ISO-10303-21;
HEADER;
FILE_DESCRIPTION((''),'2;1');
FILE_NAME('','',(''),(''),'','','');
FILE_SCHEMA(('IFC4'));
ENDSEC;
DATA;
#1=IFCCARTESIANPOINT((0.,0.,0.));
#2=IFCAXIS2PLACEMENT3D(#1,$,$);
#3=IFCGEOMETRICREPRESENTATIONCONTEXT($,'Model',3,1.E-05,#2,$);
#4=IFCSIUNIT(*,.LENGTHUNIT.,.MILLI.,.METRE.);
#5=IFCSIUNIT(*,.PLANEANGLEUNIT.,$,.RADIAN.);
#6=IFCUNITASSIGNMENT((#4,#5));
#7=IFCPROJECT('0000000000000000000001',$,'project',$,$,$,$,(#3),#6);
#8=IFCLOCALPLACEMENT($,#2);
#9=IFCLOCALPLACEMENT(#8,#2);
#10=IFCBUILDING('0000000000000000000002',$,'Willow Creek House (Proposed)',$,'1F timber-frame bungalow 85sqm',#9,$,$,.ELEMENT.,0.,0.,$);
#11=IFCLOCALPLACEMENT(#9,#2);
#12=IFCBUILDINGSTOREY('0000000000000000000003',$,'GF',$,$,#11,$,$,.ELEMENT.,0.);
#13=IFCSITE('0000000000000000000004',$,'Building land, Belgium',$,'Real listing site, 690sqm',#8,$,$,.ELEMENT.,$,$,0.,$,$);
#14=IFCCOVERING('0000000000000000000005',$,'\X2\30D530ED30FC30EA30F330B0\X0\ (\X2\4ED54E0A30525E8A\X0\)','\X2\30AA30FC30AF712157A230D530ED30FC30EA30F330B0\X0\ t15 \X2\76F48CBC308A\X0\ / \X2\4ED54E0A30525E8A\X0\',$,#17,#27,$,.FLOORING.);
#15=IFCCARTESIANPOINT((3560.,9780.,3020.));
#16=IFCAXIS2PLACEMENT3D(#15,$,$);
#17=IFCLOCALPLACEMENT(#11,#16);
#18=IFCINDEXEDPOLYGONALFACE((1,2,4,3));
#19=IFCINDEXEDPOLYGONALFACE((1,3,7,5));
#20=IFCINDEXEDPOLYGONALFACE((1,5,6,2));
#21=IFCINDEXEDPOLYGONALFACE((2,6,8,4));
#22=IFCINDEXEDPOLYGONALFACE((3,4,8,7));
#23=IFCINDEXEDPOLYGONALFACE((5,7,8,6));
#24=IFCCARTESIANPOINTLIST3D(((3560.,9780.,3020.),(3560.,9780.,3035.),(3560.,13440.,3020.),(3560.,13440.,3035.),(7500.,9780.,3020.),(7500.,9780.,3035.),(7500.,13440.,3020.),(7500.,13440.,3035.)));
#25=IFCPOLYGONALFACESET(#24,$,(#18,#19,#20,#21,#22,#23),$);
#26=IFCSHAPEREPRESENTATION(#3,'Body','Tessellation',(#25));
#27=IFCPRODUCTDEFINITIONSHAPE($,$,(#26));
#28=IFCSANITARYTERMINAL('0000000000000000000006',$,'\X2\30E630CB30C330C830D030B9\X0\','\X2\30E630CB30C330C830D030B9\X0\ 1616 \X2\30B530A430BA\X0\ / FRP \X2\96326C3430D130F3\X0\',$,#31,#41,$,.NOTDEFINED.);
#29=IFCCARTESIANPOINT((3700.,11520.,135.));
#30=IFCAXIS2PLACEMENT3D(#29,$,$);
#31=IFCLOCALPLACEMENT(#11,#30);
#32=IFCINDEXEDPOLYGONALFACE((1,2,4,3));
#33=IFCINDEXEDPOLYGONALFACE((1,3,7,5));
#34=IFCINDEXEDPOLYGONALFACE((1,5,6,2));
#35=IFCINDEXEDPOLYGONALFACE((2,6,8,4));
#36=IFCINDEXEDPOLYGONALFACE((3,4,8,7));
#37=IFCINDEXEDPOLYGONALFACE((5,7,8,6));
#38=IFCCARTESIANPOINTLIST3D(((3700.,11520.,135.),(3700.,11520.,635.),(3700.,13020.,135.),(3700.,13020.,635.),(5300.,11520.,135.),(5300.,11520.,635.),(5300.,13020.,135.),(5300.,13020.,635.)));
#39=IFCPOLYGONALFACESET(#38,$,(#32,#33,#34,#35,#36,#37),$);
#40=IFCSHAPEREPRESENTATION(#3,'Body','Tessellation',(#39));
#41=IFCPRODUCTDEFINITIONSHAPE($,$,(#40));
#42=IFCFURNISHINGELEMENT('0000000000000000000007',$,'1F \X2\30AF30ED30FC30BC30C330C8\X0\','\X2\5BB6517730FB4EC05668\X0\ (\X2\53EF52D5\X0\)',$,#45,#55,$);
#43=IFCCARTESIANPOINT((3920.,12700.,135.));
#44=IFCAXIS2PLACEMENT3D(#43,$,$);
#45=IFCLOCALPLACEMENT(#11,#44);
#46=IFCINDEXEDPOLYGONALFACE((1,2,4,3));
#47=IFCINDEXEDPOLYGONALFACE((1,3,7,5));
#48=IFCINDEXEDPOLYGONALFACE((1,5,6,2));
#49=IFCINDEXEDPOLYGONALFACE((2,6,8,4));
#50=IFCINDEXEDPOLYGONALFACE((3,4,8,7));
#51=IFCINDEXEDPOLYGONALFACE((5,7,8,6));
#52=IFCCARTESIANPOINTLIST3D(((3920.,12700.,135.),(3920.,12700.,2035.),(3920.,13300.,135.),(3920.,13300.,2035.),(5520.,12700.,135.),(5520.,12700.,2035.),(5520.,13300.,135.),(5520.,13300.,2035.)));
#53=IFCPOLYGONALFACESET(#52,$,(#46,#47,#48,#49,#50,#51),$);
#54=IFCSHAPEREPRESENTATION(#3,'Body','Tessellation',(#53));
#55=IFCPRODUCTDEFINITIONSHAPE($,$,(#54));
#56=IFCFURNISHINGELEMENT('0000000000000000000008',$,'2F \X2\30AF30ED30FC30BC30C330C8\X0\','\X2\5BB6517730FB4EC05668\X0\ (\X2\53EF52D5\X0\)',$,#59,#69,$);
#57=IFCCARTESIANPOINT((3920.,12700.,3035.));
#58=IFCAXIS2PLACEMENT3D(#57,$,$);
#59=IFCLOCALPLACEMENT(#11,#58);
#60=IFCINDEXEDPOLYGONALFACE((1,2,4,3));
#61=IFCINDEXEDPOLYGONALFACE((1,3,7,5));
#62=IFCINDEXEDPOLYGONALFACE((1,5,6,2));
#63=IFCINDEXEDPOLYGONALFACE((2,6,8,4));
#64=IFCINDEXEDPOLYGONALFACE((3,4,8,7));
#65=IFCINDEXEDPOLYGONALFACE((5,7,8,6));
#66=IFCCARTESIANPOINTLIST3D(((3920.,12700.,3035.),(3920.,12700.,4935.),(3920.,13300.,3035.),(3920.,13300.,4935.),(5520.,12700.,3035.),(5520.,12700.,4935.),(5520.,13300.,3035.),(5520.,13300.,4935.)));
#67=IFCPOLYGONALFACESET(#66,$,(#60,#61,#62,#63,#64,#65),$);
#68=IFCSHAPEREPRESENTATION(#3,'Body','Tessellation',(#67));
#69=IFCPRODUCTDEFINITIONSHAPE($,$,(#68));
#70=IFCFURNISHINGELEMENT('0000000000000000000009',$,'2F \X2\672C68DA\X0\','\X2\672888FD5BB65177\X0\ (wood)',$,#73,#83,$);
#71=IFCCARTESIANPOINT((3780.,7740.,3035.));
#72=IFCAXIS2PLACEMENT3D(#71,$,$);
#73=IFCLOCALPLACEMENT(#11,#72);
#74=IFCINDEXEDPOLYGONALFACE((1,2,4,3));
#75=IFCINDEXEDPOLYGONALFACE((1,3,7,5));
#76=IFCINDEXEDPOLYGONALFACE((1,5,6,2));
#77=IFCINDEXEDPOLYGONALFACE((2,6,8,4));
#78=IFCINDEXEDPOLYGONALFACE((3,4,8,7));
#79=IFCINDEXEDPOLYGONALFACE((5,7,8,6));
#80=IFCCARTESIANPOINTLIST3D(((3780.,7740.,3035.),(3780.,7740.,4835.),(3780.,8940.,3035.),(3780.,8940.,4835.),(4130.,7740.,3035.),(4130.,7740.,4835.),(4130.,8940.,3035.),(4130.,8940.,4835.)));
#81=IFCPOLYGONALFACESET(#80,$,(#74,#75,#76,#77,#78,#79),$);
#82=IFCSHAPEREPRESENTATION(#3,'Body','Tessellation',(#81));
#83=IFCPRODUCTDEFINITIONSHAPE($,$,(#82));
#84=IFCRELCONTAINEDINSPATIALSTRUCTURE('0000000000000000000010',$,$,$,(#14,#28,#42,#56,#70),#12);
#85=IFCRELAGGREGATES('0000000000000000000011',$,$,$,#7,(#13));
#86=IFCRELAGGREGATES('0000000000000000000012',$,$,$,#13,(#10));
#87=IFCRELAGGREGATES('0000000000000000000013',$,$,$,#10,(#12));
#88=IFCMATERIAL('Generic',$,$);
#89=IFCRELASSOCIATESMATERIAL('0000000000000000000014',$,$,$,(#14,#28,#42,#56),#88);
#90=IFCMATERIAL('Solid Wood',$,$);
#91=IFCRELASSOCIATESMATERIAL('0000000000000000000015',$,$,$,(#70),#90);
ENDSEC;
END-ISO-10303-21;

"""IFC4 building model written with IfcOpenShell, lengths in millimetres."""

from ifc_helpers import new_model, si_unit, frame, frame_2d, origin, place, context, project, spatial, rectangle, extrude, material, element, save


model = new_model("IFC4")

# Units and contexts
model_context = context("Model", 3, precision=1e-05, world=origin())
ifc_project = project(units=[si_unit("LENGTHUNIT", "METRE", prefix="MILLI"), si_unit("PLANEANGLEUNIT", "RADIAN")], contexts=[model_context])

# Site, building, storey
site_placement = place(None, origin())
site = spatial("IfcSite", under=ifc_project, at=site_placement, Name="Building land, Belgium", ObjectType="Real listing site, 690sqm", CompositionType="ELEMENT", RefElevation=0.0)
building_placement = place(site_placement, origin())
building = spatial("IfcBuilding", under=site, at=building_placement, Name="Willow Creek House (Proposed)", ObjectType="1F timber-frame bungalow 85sqm", CompositionType="ELEMENT", ElevationOfRefHeight=0.0, ElevationOfTerrain=0.0)
storey_placement = place(building_placement, origin())
storey = spatial("IfcBuildingStorey", under=building, at=storey_placement, Name="GF", CompositionType="ELEMENT", Elevation=0.0)

# Shared definitions
ifc_material_1 = material(Name="Solid Wood")

# Covering
ifc_material_2 = material(Name="Generic")
covering_1_placement = place(storey_placement, frame((3560.0, 9780.0, 3020.0)))
element("IfcCovering", 1, at=covering_1_placement, inside=storey, material=ifc_material_2, Name="フローリング (仕上げ床)", Description="オーク無垢フローリング t15 直貼り / 仕上げ床", PredefinedType="FLOORING", context=model_context, shape_type="SweptSolid", body=[
    extrude(rectangle(XDim=3940.0, YDim=3660.0, at=frame_2d((1970.0, 1830.0))), frame((3560.0, 9780.0, 3020.0)), (0.0, 0.0, 1.0), 15.0),
])

# Sanitary terminal
sanitary_terminal_placement = place(storey_placement, frame((3700.0, 11520.0, 135.0)))
element("IfcSanitaryTerminal", 2, at=sanitary_terminal_placement, inside=storey, material=ifc_material_2, Name="ユニットバス", Description="ユニットバス 1616 サイズ / FRP 防水パン", PredefinedType="NOTDEFINED", context=model_context, shape_type="SweptSolid", body=[
    extrude(rectangle(XDim=1600.0, YDim=1500.0, at=frame_2d((800.0, 750.0))), frame((3700.0, 11520.0, 135.0)), (0.0, 0.0, 1.0), 500.0),
])

# Furnishing elements
furnishing_1_placement = place(storey_placement, frame((3920.0, 12700.0, 135.0)))
element("IfcFurnishingElement", 3, at=furnishing_1_placement, inside=storey, material=ifc_material_2, Name="1F クローゼット", Description="家具・什器 (可動)", context=model_context, shape_type="SweptSolid", body=[
    extrude(rectangle(XDim=1600.0, YDim=600.0, at=frame_2d((800.0, 300.0))), frame((3920.0, 12700.0, 135.0)), (0.0, 0.0, 1.0), 1900.0),
])
furnishing_2_placement = place(storey_placement, frame((3920.0, 12700.0, 3035.0)))
element("IfcFurnishingElement", 4, at=furnishing_2_placement, inside=storey, material=ifc_material_2, Name="2F クローゼット", Description="家具・什器 (可動)", context=model_context, shape_type="SweptSolid", body=[
    extrude(rectangle(XDim=1600.0, YDim=600.0, at=frame_2d((800.0, 300.0))), frame((3920.0, 12700.0, 3035.0)), (0.0, 0.0, 1.0), 1900.0),
])
furnishing_3_placement = place(storey_placement, frame((3780.0, 7740.0, 3035.0)))
element("IfcFurnishingElement", 5, at=furnishing_3_placement, inside=storey, material=ifc_material_1, Name="2F 本棚", Description="木製家具 (wood)", context=model_context, shape_type="SweptSolid", body=[
    extrude(rectangle(XDim=350.0, YDim=1200.0, at=frame_2d((175.0, 600.0))), frame((3780.0, 7740.0, 3035.0)), (0.0, 0.0, 1.0), 1800.0),
])

save(model, "model.ifc")
